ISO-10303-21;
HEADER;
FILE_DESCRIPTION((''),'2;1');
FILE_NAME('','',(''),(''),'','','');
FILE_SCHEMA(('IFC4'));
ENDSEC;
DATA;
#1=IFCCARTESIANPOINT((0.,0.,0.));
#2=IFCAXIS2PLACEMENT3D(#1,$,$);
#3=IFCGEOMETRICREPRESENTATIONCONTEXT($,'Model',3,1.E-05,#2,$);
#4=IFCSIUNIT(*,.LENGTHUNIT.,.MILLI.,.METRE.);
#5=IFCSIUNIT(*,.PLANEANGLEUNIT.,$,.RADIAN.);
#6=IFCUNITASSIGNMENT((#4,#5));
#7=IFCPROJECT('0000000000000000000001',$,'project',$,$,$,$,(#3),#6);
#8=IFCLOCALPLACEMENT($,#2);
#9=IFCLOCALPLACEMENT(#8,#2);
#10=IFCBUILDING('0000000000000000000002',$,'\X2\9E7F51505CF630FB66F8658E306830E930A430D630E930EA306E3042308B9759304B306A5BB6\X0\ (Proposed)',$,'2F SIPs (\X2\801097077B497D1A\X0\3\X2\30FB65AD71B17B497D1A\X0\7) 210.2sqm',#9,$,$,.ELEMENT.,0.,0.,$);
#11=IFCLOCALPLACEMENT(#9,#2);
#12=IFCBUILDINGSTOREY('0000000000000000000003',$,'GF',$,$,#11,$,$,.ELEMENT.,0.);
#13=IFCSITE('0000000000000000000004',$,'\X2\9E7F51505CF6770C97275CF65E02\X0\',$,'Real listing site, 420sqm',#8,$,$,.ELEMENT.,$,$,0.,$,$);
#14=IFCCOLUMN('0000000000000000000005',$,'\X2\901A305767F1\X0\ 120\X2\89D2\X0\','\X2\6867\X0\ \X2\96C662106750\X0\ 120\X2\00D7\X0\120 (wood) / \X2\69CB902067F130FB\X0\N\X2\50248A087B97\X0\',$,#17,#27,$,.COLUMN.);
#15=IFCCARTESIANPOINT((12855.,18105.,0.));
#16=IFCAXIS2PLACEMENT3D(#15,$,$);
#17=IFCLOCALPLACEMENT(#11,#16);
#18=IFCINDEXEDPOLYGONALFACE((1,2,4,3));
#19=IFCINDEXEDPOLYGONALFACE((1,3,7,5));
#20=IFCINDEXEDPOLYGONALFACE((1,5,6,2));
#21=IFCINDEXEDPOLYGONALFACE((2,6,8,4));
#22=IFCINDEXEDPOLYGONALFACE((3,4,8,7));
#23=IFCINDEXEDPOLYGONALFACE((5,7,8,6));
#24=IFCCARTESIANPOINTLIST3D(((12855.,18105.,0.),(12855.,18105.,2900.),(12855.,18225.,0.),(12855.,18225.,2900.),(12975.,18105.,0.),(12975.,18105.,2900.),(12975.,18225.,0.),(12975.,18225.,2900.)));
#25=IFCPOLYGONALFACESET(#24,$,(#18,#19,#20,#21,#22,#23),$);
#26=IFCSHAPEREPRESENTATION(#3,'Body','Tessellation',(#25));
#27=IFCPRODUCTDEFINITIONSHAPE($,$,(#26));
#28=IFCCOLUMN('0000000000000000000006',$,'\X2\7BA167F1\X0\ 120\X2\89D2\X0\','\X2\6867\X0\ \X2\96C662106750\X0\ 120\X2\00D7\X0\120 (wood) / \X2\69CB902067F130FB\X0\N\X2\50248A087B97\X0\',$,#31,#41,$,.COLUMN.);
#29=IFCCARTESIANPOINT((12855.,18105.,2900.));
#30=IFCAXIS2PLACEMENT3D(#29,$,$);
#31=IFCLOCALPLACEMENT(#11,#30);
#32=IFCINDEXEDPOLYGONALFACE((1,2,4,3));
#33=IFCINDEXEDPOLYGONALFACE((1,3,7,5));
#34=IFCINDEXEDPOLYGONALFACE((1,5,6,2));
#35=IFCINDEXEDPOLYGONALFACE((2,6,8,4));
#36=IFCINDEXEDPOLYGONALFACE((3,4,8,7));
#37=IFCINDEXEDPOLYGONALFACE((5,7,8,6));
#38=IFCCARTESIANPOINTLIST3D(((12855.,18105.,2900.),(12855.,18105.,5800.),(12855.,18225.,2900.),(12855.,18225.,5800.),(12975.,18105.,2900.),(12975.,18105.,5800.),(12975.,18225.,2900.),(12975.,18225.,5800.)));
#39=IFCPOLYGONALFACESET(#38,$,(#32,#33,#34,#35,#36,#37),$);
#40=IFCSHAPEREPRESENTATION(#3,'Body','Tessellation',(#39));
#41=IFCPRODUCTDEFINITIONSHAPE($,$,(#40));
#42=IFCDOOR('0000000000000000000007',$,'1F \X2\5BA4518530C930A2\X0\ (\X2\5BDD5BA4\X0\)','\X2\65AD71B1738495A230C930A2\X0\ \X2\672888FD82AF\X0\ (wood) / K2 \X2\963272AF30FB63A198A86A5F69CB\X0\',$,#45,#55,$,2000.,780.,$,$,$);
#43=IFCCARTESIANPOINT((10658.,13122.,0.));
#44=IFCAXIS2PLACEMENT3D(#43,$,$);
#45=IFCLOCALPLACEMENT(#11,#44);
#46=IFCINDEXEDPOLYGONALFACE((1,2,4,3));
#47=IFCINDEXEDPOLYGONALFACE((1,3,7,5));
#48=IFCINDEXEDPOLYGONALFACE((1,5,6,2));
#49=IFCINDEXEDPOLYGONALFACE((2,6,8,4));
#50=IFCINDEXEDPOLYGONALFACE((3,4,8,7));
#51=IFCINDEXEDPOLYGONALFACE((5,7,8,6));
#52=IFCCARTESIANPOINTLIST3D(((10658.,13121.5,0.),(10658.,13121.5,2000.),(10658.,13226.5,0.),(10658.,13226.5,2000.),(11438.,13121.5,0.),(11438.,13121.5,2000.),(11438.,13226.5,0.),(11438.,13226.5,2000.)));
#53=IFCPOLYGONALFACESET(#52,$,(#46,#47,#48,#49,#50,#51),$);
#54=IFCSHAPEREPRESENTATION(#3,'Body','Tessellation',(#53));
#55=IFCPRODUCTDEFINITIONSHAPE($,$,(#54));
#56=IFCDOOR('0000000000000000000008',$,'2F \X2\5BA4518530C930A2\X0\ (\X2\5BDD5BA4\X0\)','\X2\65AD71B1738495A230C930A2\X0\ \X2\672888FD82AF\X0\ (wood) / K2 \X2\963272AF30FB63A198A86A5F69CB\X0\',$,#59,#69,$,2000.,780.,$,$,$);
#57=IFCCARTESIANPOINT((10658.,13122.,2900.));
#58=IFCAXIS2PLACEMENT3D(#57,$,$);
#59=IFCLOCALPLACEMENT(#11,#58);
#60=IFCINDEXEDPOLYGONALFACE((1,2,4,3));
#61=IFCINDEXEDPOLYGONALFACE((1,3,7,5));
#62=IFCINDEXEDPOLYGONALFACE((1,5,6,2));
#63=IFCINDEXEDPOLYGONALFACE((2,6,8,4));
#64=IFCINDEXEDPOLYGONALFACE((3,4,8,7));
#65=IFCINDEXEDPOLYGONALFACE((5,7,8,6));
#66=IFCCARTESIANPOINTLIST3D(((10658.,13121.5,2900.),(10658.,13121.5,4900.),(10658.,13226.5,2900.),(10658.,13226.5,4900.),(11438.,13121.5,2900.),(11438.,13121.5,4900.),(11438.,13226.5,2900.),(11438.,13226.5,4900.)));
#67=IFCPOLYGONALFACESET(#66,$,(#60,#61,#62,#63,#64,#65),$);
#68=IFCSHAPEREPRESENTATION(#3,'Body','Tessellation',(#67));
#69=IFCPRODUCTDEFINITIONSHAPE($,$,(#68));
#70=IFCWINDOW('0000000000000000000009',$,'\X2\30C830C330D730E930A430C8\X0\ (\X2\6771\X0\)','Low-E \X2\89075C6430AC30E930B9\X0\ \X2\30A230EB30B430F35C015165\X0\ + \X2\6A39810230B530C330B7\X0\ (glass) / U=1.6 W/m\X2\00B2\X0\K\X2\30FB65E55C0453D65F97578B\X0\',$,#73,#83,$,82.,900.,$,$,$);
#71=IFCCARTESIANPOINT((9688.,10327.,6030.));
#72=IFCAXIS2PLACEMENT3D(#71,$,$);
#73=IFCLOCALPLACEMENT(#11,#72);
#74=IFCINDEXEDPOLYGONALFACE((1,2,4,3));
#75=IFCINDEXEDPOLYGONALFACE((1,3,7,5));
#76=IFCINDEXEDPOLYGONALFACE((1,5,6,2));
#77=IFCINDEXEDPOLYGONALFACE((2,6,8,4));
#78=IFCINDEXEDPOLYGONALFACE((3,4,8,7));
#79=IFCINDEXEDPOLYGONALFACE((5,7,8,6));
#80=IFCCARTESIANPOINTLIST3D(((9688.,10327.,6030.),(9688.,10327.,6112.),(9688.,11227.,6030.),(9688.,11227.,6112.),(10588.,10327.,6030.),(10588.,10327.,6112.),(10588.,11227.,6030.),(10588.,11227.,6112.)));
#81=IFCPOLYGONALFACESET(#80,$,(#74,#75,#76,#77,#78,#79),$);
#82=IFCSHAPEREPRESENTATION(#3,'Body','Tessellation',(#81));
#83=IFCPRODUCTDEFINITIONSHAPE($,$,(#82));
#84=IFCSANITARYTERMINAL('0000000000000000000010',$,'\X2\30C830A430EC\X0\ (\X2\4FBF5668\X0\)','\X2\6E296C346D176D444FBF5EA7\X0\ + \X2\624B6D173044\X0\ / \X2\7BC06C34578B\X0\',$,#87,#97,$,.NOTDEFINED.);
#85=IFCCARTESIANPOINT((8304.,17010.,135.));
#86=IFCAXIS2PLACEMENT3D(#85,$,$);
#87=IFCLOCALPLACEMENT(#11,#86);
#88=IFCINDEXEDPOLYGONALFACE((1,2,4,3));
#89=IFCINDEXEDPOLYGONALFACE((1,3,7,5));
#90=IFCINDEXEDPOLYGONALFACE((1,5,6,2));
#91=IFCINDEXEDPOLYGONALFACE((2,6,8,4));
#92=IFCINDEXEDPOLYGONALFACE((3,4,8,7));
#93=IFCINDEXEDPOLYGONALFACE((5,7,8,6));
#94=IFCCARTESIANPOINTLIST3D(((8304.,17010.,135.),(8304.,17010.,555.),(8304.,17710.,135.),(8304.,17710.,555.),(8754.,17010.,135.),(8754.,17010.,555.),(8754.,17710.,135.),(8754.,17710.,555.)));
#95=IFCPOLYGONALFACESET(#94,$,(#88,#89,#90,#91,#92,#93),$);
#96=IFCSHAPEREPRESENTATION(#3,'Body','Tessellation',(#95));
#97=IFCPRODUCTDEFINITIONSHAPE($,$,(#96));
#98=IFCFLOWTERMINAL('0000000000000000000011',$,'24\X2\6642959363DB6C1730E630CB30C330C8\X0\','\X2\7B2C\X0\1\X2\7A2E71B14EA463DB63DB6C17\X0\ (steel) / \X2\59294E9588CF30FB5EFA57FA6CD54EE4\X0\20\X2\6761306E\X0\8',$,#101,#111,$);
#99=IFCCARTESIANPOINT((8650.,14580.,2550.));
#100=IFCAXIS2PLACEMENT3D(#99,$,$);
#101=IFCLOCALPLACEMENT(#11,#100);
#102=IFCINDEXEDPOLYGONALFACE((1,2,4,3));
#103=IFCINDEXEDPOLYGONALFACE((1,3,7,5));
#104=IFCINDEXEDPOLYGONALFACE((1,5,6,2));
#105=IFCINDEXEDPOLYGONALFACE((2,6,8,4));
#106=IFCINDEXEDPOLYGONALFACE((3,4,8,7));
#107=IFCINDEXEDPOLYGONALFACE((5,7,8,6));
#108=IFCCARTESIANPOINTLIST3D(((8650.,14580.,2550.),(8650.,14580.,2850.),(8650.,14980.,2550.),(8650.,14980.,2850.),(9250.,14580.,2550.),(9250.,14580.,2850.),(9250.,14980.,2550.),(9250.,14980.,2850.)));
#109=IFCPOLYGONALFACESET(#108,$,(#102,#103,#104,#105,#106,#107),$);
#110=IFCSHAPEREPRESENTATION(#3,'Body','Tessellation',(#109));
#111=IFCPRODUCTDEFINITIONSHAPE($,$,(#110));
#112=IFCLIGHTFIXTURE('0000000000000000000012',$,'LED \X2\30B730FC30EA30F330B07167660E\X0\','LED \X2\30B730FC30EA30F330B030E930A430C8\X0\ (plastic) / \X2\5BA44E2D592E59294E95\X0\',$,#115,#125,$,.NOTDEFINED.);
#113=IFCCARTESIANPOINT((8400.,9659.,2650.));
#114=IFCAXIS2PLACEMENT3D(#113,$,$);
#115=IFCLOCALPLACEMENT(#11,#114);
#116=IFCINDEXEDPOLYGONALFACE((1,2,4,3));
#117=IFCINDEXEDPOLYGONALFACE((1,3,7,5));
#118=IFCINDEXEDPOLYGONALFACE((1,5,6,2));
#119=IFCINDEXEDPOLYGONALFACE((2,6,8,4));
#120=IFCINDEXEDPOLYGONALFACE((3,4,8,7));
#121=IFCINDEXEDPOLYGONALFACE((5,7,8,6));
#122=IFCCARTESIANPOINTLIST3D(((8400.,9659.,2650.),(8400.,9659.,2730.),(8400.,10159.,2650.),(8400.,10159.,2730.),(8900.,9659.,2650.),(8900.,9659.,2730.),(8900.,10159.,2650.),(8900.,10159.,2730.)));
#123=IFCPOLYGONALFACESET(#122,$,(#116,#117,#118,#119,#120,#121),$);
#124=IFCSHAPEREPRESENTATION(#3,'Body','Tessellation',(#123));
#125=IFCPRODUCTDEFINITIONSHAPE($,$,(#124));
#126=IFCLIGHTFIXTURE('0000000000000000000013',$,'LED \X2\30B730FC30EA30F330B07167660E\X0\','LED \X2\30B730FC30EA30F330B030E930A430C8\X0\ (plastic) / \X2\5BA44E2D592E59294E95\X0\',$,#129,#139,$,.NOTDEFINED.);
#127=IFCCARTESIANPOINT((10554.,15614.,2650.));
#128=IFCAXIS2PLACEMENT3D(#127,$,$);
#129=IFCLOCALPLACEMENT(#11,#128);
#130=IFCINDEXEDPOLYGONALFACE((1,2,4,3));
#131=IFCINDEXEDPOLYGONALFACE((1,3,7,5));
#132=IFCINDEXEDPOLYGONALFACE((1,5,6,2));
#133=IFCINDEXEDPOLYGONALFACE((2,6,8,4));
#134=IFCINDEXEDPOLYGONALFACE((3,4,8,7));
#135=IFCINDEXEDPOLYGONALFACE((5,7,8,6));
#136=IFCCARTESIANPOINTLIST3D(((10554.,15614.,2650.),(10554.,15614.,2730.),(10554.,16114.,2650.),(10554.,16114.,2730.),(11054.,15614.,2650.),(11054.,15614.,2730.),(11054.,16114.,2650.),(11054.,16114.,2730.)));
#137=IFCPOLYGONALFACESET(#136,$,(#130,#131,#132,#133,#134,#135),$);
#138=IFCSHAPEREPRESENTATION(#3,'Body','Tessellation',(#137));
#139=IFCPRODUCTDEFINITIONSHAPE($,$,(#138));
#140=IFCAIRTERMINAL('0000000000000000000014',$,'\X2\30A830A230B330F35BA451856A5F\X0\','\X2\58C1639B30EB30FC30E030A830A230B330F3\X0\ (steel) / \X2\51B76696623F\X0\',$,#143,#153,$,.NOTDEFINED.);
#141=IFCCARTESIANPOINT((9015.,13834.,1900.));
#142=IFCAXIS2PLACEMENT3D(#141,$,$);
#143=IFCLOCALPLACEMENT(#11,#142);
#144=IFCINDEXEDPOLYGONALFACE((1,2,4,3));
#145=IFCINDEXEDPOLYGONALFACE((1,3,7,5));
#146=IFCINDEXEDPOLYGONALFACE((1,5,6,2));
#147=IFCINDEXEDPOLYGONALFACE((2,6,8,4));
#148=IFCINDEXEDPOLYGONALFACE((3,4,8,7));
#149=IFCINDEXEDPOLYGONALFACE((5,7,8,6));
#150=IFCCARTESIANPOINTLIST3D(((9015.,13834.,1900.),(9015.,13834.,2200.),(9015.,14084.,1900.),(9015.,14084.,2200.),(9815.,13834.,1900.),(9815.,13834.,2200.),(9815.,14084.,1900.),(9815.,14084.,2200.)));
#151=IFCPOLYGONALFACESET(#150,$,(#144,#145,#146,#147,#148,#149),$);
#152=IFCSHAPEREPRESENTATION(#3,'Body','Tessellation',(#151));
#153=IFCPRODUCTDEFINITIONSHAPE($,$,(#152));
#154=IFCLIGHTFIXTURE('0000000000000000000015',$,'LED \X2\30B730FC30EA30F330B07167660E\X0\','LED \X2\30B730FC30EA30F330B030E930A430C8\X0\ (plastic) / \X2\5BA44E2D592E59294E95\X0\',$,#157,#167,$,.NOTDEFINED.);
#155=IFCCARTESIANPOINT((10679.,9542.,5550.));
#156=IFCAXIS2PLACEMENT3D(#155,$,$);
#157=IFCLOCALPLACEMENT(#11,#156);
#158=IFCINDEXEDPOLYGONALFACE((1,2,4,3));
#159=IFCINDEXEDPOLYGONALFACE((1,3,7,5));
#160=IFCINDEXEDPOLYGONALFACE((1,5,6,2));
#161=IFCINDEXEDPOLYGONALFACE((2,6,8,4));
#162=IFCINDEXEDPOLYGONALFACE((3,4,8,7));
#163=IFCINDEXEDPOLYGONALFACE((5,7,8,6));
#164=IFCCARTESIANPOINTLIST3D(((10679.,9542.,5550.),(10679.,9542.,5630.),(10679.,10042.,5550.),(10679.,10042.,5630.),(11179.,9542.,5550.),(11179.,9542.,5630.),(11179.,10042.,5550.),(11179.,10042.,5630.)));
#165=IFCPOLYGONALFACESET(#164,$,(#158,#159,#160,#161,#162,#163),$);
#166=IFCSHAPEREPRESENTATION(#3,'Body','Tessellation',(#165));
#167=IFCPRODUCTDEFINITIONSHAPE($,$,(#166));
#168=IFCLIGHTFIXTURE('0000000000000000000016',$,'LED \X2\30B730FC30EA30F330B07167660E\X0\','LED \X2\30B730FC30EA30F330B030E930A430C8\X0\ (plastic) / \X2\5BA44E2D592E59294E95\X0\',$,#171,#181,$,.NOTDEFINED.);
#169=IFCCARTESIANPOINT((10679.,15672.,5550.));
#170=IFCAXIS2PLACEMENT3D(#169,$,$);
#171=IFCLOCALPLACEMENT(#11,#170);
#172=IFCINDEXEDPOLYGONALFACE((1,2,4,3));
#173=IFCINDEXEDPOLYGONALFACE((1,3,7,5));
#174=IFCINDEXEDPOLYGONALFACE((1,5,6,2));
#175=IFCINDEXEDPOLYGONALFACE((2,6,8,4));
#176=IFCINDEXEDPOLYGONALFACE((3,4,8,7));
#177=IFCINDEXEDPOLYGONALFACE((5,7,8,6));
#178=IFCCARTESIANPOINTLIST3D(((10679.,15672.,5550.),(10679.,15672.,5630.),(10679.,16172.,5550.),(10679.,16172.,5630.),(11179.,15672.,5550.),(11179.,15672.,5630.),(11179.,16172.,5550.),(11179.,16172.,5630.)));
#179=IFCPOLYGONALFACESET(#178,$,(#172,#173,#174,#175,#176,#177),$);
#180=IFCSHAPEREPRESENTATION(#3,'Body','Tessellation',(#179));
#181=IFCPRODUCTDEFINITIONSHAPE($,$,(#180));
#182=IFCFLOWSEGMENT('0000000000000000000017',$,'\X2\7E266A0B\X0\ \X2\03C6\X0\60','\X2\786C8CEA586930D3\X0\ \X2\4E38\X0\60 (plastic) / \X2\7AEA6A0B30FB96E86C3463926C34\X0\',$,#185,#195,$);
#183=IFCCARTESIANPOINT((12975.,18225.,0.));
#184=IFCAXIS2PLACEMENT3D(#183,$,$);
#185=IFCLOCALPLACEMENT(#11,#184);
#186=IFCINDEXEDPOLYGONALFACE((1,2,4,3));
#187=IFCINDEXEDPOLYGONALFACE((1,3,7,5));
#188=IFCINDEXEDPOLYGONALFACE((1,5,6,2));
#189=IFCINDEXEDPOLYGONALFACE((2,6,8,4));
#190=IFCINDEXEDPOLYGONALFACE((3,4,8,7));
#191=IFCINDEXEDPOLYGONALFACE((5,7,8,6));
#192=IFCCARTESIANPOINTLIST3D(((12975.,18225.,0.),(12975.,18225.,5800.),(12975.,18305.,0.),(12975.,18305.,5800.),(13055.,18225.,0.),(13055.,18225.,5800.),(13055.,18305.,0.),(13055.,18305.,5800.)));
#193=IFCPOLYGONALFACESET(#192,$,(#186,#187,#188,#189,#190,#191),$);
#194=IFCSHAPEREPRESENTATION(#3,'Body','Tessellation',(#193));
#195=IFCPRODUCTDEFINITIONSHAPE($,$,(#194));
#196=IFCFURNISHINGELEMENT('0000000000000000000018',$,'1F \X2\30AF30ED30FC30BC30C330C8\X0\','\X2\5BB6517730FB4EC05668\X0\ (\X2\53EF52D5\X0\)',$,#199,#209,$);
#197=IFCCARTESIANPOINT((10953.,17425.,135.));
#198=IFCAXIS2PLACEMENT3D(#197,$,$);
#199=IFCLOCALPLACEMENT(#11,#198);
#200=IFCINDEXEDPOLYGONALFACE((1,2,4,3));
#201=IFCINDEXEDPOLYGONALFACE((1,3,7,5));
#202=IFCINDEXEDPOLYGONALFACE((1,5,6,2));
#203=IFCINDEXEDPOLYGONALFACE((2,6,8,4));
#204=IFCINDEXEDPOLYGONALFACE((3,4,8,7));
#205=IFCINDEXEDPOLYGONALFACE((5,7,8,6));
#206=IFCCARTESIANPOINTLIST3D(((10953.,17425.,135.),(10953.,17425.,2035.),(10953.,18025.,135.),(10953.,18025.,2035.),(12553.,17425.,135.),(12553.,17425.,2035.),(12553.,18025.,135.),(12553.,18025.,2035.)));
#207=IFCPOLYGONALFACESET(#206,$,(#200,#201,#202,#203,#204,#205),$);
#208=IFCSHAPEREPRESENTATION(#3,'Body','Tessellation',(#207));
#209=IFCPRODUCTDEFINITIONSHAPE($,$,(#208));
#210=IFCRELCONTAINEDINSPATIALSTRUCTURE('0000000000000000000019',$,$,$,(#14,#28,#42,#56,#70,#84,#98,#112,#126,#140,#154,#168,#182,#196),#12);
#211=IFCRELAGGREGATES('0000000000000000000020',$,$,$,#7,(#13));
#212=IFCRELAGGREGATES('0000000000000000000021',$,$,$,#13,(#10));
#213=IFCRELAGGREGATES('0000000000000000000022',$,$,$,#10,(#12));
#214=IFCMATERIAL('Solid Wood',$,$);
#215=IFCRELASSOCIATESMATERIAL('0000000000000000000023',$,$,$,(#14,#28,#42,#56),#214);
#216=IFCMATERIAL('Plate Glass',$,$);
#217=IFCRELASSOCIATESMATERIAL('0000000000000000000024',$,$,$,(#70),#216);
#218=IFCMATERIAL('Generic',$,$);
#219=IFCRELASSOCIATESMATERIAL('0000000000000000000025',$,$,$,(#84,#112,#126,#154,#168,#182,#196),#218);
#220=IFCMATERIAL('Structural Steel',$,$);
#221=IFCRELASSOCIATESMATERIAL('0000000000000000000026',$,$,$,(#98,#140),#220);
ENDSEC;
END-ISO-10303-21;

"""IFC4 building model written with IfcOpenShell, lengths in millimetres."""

from ifc_helpers import new_model, si_unit, frame, frame_2d, origin, place, context, project, spatial, rectangle, extrude, material, element, save


model = new_model("IFC4")

# Units and contexts
model_context = context("Model", 3, precision=1e-05, world=origin())
ifc_project = project(units=[si_unit("LENGTHUNIT", "METRE", prefix="MILLI"), si_unit("PLANEANGLEUNIT", "RADIAN")], contexts=[model_context])

# Site, building, storey
site_placement = place(None, origin())
site = spatial("IfcSite", under=ifc_project, at=site_placement, Name="鹿児島県霧島市", ObjectType="Real listing site, 420sqm", CompositionType="ELEMENT", RefElevation=0.0)
building_placement = place(site_placement, origin())
building = spatial("IfcBuilding", under=site, at=building_placement, Name="鹿児島・書斎とライブラリのある静かな家 (Proposed)", ObjectType="2F SIPs (耐震等級3・断熱等級7) 210.2sqm", CompositionType="ELEMENT", ElevationOfRefHeight=0.0, ElevationOfTerrain=0.0)
storey_placement = place(building_placement, origin())
storey = spatial("IfcBuildingStorey", under=building, at=storey_placement, Name="GF", CompositionType="ELEMENT", Elevation=0.0)

# Columns
ifc_material_1 = material(Name="Solid Wood")
column_1_placement = place(storey_placement, frame((12855.0, 18105.0, 0.0)))
element("IfcColumn", 1, at=column_1_placement, inside=storey, material=ifc_material_1, Name="通し柱 120角", Description="桧 集成材 120×120 (wood) / 構造柱・N値計算", PredefinedType="COLUMN", context=model_context, shape_type="SweptSolid", body=[
    extrude(rectangle(XDim=120.0, YDim=120.0, at=frame_2d((60.0, 60.0))), frame((12855.0, 18105.0, 0.0)), (0.0, 0.0, 1.0), 2900.0),
])
column_2_placement = place(storey_placement, frame((12855.0, 18105.0, 2900.0)))
element("IfcColumn", 2, at=column_2_placement, inside=storey, material=ifc_material_1, Name="管柱 120角", Description="桧 集成材 120×120 (wood) / 構造柱・N値計算", PredefinedType="COLUMN", context=model_context, shape_type="SweptSolid", body=[
    extrude(rectangle(XDim=120.0, YDim=120.0, at=frame_2d((60.0, 60.0))), frame((12855.0, 18105.0, 2900.0)), (0.0, 0.0, 1.0), 2900.0),
])

# Door
door_1_placement = place(storey_placement, frame((10658.0, 13122.0, 0.0)))
element("IfcDoor", 3, at=door_1_placement, inside=storey, material=ifc_material_1, Name="1F 室内ドア (寝室)", Description="断熱玄関ドア 木製芯 (wood) / K2 防犯・採風機構", OverallHeight=2000.0, OverallWidth=780.0, context=model_context, shape_type="SweptSolid", body=[
    extrude(rectangle(XDim=780.0, YDim=105.0, at=frame_2d((390.0, 52.0))), frame((10658.0, 13122.0, 0.0)), (0.0, 0.0, 1.0), 2000.0),
])

# Door
door_2_placement = place(storey_placement, frame((10658.0, 13122.0, 2900.0)))
element("IfcDoor", 4, at=door_2_placement, inside=storey, material=ifc_material_1, Name="2F 室内ドア (寝室)", Description="断熱玄関ドア 木製芯 (wood) / K2 防犯・採風機構", OverallHeight=2000.0, OverallWidth=780.0, context=model_context, shape_type="SweptSolid", body=[
    extrude(rectangle(XDim=780.0, YDim=105.0, at=frame_2d((390.0, 52.0))), frame((10658.0, 13122.0, 2900.0)), (0.0, 0.0, 1.0), 2000.0),
])

# Window
ifc_material_2 = material(Name="Plate Glass")
window_placement = place(storey_placement, frame((9688.0, 10327.0, 6030.0)))
element("IfcWindow", 5, at=window_placement, inside=storey, material=ifc_material_2, Name="トップライト (東)", Description="Low-E 複層ガラス アルゴン封入 + 樹脂サッシ (glass) / U=1.6 W/m²K・日射取得型", OverallHeight=82.0, OverallWidth=900.0, context=model_context, shape_type="SweptSolid", body=[
    extrude(rectangle(XDim=900.0, YDim=900.0, at=frame_2d((450.0, 450.0))), frame((9688.0, 10327.0, 6030.0)), (0.0, 0.0, 1.0), 82.0),
])

# Sanitary terminal
ifc_material_3 = material(Name="Generic")
sanitary_terminal_placement = place(storey_placement, frame((8304.0, 17010.0, 135.0)))
element("IfcSanitaryTerminal", 6, at=sanitary_terminal_placement, inside=storey, material=ifc_material_3, Name="トイレ (便器)", Description="温水洗浄便座 + 手洗い / 節水型", PredefinedType="NOTDEFINED", context=model_context, shape_type="SweptSolid", body=[
    extrude(rectangle(XDim=450.0, YDim=700.0, at=frame_2d((225.0, 350.0))), frame((8304.0, 17010.0, 135.0)), (0.0, 0.0, 1.0), 420.0),
])

# Flow terminal
ifc_material_4 = material(Name="Structural Steel")
flow_terminal_placement = place(storey_placement, frame((8650.0, 14580.0, 2550.0)))
element("IfcFlowTerminal", 7, at=flow_terminal_placement, inside=storey, material=ifc_material_4, Name="24時間換気ユニット", Description="第1種熱交換換気 (steel) / 天井裏・建基法令20条の8", context=model_context, shape_type="SweptSolid", body=[
    extrude(rectangle(XDim=600.0, YDim=400.0, at=frame_2d((300.0, 200.0))), frame((8650.0, 14580.0, 2550.0)), (0.0, 0.0, 1.0), 300.0),
])

# Light fixtures
light_fixture_1_placement = place(storey_placement, frame((8400.0, 9659.0, 2650.0)))
element("IfcLightFixture", 8, at=light_fixture_1_placement, inside=storey, material=ifc_material_3, Name="LED シーリング照明", Description="LED シーリングライト (plastic) / 室中央天井", PredefinedType="NOTDEFINED", context=model_context, shape_type="SweptSolid", body=[
    extrude(rectangle(XDim=500.0, YDim=500.0, at=frame_2d((250.0, 250.0))), frame((8400.0, 9659.0, 2650.0)), (0.0, 0.0, 1.0), 80.0),
])
light_fixture_2_placement = place(storey_placement, frame((10554.0, 15614.0, 2650.0)))
element("IfcLightFixture", 9, at=light_fixture_2_placement, inside=storey, material=ifc_material_3, Name="LED シーリング照明", Description="LED シーリングライト (plastic) / 室中央天井", PredefinedType="NOTDEFINED", context=model_context, shape_type="SweptSolid", body=[
    extrude(rectangle(XDim=500.0, YDim=500.0, at=frame_2d((250.0, 250.0))), frame((10554.0, 15614.0, 2650.0)), (0.0, 0.0, 1.0), 80.0),
])

# Air terminal
air_terminal_placement = place(storey_placement, frame((9015.0, 13834.0, 1900.0)))
element("IfcAirTerminal", 10, at=air_terminal_placement, inside=storey, material=ifc_material_4, Name="エアコン室内機", Description="壁掛ルームエアコン (steel) / 冷暖房", PredefinedType="NOTDEFINED", context=model_context, shape_type="SweptSolid", body=[
    extrude(rectangle(XDim=800.0, YDim=250.0, at=frame_2d((400.0, 125.0))), frame((9015.0, 13834.0, 1900.0)), (0.0, 0.0, 1.0), 300.0),
])

# Light fixtures
light_fixture_3_placement = place(storey_placement, frame((10679.0, 9542.0, 5550.0)))
element("IfcLightFixture", 11, at=light_fixture_3_placement, inside=storey, material=ifc_material_3, Name="LED シーリング照明", Description="LED シーリングライト (plastic) / 室中央天井", PredefinedType="NOTDEFINED", context=model_context, shape_type="SweptSolid", body=[
    extrude(rectangle(XDim=500.0, YDim=500.0, at=frame_2d((250.0, 250.0))), frame((10679.0, 9542.0, 5550.0)), (0.0, 0.0, 1.0), 80.0),
])
light_fixture_4_placement = place(storey_placement, frame((10679.0, 15672.0, 5550.0)))
element("IfcLightFixture", 12, at=light_fixture_4_placement, inside=storey, material=ifc_material_3, Name="LED シーリング照明", Description="LED シーリングライト (plastic) / 室中央天井", PredefinedType="NOTDEFINED", context=model_context, shape_type="SweptSolid", body=[
    extrude(rectangle(XDim=500.0, YDim=500.0, at=frame_2d((250.0, 250.0))), frame((10679.0, 15672.0, 5550.0)), (0.0, 0.0, 1.0), 80.0),
])

# Flow segment
flow_segment_placement = place(storey_placement, frame((12975.0, 18225.0, 0.0)))
element("IfcFlowSegment", 13, at=flow_segment_placement, inside=storey, material=ifc_material_3, Name="縦樋 φ60", Description="硬質塩ビ 丸60 (plastic) / 竪樋・雨水排水", context=model_context, shape_type="SweptSolid", body=[
    extrude(rectangle(XDim=80.0, YDim=80.0, at=frame_2d((40.0, 40.0))), frame((12975.0, 18225.0, 0.0)), (0.0, 0.0, 1.0), 5800.0),
])

# Furnishing element
furnishing_1_placement = place(storey_placement, frame((10953.0, 17425.0, 135.0)))
element("IfcFurnishingElement", 14, at=furnishing_1_placement, inside=storey, material=ifc_material_3, Name="1F クローゼット", Description="家具・什器 (可動)", context=model_context, shape_type="SweptSolid", body=[
    extrude(rectangle(XDim=1600.0, YDim=600.0, at=frame_2d((800.0, 300.0))), frame((10953.0, 17425.0, 135.0)), (0.0, 0.0, 1.0), 1900.0),
])

save(model, "model.ifc")
